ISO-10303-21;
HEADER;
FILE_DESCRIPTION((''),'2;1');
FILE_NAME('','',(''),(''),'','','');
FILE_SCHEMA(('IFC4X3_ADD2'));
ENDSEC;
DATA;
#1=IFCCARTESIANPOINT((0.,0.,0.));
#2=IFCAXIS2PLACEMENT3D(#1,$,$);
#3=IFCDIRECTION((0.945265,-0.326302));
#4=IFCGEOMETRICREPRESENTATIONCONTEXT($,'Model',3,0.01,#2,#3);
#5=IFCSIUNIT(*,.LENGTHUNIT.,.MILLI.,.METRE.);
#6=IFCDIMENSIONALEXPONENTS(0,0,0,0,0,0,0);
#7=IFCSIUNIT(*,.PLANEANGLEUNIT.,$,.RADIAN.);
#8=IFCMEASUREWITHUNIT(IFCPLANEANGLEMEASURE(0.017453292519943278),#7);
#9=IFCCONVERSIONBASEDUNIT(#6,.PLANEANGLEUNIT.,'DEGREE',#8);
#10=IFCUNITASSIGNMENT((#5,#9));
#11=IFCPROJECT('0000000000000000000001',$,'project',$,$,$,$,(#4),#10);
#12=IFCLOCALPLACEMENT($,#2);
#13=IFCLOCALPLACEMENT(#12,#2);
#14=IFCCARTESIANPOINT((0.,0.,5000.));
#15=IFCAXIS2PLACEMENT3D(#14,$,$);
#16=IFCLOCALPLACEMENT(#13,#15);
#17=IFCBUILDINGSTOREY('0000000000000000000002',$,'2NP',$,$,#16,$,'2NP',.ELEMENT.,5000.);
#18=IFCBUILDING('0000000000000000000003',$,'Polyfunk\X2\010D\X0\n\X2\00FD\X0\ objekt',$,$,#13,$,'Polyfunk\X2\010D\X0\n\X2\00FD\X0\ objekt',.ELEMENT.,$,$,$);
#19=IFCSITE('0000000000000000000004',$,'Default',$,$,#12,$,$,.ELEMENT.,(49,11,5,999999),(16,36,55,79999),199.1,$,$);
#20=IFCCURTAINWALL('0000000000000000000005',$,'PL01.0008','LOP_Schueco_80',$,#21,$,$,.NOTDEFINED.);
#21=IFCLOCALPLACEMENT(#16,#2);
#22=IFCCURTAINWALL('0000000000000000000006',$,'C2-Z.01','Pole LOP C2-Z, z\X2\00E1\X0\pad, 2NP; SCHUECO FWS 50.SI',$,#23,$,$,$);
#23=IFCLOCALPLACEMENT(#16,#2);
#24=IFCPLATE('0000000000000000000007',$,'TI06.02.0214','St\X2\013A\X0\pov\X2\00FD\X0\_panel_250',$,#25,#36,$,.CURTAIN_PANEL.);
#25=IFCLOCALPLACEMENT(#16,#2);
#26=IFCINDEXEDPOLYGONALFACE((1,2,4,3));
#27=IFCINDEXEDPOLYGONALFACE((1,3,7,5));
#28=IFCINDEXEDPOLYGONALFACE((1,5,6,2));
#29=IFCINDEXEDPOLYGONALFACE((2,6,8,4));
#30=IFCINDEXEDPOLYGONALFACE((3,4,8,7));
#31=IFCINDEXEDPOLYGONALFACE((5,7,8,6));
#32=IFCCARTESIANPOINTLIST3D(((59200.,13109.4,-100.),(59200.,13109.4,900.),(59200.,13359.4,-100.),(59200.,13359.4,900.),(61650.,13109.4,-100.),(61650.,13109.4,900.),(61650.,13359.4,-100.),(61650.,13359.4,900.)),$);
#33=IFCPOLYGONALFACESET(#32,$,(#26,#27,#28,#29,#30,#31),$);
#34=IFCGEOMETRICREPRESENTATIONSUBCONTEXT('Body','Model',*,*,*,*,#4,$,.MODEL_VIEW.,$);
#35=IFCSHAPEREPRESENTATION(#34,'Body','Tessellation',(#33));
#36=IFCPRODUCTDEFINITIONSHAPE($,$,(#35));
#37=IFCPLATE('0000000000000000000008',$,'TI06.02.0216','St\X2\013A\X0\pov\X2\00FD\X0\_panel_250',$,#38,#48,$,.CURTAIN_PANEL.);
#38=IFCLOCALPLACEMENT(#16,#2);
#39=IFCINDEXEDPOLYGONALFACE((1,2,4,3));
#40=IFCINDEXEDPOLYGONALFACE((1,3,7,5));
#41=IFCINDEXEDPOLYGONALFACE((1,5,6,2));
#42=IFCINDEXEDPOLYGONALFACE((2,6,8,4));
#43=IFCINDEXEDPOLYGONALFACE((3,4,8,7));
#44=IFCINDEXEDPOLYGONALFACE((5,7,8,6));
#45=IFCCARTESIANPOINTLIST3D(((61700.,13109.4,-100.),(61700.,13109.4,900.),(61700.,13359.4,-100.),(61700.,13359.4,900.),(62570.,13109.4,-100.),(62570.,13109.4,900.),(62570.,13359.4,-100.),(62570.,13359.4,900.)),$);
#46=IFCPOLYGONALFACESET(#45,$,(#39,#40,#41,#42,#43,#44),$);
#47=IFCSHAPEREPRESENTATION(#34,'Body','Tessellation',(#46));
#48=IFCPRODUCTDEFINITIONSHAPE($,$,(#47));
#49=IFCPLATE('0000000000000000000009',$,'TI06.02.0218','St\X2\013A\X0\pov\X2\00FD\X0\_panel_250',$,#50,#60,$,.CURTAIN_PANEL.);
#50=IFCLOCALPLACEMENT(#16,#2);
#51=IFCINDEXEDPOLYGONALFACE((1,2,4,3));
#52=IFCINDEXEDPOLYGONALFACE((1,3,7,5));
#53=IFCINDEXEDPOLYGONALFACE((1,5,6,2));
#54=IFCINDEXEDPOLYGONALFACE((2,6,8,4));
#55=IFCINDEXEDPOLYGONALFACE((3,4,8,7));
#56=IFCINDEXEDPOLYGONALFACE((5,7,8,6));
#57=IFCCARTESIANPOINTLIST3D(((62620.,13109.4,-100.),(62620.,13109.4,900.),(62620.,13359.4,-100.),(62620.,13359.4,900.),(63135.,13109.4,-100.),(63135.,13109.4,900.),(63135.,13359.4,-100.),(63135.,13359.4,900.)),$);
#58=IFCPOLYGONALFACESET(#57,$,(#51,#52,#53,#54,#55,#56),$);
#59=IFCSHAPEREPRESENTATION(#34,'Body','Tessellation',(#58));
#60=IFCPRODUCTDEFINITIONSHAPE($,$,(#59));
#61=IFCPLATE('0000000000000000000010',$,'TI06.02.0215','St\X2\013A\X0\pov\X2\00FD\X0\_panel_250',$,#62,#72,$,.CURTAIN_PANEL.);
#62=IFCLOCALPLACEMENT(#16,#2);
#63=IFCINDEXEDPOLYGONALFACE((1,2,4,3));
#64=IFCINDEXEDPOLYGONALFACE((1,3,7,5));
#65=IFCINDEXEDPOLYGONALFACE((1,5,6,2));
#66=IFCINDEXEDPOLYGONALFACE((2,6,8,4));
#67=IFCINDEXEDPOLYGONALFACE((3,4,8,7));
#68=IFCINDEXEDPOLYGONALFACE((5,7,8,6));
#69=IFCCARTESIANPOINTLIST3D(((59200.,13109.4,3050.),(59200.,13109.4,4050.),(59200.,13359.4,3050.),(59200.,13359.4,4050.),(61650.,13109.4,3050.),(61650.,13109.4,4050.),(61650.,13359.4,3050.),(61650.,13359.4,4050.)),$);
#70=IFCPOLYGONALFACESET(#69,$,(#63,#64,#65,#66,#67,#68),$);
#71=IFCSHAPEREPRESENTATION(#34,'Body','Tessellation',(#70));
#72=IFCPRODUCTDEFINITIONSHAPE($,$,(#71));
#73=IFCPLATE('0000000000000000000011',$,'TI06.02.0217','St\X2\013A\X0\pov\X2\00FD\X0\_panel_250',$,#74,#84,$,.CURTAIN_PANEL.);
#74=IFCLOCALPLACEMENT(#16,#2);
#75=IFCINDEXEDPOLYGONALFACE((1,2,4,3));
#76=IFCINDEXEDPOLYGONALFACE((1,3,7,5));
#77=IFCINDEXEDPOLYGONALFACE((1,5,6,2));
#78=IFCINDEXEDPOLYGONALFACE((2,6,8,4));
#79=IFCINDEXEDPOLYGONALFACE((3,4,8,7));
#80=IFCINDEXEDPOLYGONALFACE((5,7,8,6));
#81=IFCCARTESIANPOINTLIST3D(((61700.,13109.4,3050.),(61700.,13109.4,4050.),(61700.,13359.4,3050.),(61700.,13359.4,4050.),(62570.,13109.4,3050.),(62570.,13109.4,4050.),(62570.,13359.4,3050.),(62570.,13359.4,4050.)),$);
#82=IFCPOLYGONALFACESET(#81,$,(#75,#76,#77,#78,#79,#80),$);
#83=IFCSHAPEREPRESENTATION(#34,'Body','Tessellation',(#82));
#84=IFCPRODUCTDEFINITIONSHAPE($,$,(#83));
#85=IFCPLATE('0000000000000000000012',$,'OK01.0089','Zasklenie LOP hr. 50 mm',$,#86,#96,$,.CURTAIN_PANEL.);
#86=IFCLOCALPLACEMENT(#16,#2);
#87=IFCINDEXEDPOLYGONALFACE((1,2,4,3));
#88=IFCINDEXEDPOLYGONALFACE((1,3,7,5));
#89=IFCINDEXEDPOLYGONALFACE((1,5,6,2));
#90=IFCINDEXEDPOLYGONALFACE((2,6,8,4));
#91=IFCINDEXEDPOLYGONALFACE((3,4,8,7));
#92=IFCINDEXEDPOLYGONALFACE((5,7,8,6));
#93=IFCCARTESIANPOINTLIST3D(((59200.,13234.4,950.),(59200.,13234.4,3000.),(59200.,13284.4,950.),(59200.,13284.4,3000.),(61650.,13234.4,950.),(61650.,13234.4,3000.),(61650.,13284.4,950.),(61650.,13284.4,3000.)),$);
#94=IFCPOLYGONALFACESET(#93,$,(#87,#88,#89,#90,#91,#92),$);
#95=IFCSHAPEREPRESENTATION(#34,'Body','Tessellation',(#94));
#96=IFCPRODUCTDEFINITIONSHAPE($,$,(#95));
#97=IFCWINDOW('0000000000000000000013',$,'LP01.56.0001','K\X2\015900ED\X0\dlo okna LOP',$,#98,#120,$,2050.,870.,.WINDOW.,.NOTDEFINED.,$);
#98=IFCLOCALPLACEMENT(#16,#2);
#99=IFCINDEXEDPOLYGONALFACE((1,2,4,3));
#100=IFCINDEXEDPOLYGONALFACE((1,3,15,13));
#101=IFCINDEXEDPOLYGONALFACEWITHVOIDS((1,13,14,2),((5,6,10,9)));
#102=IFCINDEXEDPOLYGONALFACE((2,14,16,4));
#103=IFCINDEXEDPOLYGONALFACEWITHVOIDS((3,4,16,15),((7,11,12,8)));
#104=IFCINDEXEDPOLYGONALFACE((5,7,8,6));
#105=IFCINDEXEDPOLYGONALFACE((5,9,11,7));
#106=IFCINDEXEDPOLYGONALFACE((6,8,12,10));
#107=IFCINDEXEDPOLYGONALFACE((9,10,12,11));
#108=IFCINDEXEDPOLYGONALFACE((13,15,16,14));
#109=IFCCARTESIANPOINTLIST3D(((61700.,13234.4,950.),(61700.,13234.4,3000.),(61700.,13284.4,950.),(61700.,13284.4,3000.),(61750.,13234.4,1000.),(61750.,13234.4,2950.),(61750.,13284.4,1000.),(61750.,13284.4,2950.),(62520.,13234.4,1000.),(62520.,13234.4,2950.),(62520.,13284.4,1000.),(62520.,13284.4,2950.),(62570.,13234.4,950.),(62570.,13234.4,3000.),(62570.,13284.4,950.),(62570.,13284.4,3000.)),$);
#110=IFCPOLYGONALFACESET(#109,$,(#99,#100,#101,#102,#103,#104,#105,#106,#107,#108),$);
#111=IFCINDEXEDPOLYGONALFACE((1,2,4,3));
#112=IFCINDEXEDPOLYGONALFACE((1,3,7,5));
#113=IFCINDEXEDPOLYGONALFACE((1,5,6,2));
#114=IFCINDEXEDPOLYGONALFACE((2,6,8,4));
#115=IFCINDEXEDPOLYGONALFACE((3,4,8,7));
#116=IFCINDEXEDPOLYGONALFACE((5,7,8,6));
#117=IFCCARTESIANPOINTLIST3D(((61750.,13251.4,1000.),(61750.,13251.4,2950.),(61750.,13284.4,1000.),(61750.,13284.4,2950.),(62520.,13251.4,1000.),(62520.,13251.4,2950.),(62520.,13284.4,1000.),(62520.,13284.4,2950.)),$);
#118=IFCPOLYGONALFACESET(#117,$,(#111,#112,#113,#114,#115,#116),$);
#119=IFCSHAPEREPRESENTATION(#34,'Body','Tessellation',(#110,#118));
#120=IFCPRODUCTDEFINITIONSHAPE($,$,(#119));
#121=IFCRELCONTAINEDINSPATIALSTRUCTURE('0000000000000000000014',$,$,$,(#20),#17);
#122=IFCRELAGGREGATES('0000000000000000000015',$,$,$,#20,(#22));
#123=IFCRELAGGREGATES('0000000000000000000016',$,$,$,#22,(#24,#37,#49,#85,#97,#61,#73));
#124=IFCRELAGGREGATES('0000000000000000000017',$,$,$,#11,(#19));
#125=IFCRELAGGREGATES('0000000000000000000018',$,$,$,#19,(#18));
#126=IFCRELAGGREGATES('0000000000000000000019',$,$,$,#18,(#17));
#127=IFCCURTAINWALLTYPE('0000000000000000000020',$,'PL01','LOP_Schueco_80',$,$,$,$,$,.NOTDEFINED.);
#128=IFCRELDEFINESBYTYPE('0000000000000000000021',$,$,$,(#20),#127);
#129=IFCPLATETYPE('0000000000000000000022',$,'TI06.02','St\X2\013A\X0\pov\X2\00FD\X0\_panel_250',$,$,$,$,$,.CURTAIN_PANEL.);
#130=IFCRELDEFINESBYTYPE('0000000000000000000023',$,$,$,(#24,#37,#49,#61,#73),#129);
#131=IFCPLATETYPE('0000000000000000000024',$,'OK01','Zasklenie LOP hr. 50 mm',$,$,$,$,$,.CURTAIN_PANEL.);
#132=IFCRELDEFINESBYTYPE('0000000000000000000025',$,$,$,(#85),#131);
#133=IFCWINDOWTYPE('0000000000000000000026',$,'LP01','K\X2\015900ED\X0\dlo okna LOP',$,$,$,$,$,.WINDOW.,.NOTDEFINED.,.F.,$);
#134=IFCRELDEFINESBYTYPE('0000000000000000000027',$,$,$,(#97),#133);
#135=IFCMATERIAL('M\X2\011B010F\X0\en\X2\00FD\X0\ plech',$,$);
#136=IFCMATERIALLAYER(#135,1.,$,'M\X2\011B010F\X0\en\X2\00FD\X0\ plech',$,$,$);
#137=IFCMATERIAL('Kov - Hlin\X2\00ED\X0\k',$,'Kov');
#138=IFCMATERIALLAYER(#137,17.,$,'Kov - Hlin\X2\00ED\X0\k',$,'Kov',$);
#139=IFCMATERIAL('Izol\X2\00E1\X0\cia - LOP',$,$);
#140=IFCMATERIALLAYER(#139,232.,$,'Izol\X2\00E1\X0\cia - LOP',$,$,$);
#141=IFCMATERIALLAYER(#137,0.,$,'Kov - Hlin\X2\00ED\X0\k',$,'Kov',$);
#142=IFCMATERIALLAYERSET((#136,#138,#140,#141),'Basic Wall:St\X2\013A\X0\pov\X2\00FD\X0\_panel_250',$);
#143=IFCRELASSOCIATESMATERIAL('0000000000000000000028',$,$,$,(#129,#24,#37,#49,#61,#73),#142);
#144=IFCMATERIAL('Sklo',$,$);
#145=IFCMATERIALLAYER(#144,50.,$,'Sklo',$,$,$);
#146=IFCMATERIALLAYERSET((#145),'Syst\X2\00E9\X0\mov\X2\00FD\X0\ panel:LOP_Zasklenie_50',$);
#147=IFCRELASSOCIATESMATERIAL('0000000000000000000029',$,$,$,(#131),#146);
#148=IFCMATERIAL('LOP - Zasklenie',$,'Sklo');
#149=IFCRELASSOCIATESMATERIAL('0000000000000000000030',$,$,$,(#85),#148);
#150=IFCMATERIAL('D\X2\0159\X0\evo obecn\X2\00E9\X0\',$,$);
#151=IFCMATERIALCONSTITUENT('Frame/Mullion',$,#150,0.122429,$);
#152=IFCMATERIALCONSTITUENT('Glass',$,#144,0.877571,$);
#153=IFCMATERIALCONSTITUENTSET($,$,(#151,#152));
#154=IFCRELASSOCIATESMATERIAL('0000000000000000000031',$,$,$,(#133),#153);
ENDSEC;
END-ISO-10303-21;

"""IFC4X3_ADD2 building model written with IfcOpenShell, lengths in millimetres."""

from ifc_helpers import new_model, entity, si_unit, converted_unit, direction, frame, frame_2d, origin, origin_2d_with_axis, place, context, subcontext, project, spatial, polyline, rectangle, outline, extrude, source, transform, mapped, material, layer, layer_set, layer_usage, constituent, constituent_set, type_object, type_shapes, element, aggregate, save


model = new_model("IFC4X3_ADD2")

# Units and contexts
model_context = context("Model", 3, precision=0.01, world=origin(), true_north=direction((0.945265, -0.326302)))
body_context = subcontext(model_context, "Body", "Model", "MODEL_VIEW")
ifc_project = project(units=[si_unit("LENGTHUNIT", "METRE", prefix="MILLI"), converted_unit("PLANEANGLEUNIT", "DEGREE", entity("IfcPlaneAngleMeasure", 0.017453292519943278), si_unit("PLANEANGLEUNIT", "RADIAN"), dimensions=[0, 0, 0, 0, 0, 0, 0])], contexts=[model_context])

# Site, building, storey
site_placement = place(None, origin())
site = spatial("IfcSite", under=ifc_project, at=site_placement, Name="Default", CompositionType="ELEMENT", RefLatitude=(49, 11, 5, 999999), RefLongitude=(16, 36, 55, 79999), RefElevation=199.1)
building_placement = place(site_placement, origin())
building = spatial("IfcBuilding", under=site, at=building_placement, Name="Polyfunkčný objekt", LongName="Polyfunkčný objekt", CompositionType="ELEMENT")
storey_placement = place(building_placement, frame((0.0, 0.0, 5000.0)))
storey = spatial("IfcBuildingStorey", under=building, at=storey_placement, Name="2NP", LongName="2NP", CompositionType="ELEMENT", Elevation=5000.0)

# Curtain walls, plates, window
curtain_wall_type = type_object("IfcCurtainWallType", Name="PL01", Description="LOP_Schueco_80", PredefinedType="NOTDEFINED")
curtain_wall_1_placement = place(storey_placement, frame((0.0, 0.0, -5000.0)))
curtain_wall_1 = element("IfcCurtainWall", 1, at=curtain_wall_1_placement, inside=storey, type_object=curtain_wall_type, Name="PL01.0008", Description="LOP_Schueco_80", PredefinedType="NOTDEFINED")
curtain_wall_2 = element("IfcCurtainWall", 2, Name="C2-Z.01", Description="Pole LOP C2-Z, západ, 2NP; SCHUECO FWS 50.SI")
aggregate(curtain_wall_1, [curtain_wall_2])
ifc_material_1 = material(Name="Měďený plech")
ifc_layer_1 = layer(ifc_material_1, 1.0, Name="Měďený plech")
ifc_material_2 = material(Name="Kov - Hliník", Category="Kov")
ifc_layer_2 = layer(ifc_material_2, 17.0, Name="Kov - Hliník", Category="Kov")
ifc_material_3 = material(Name="Izolácia - LOP")
ifc_layer_3 = layer(ifc_material_3, 232.0, Name="Izolácia - LOP")
ifc_layer_4 = layer(ifc_material_2, 0.0, Name="Kov - Hliník", Category="Kov")
ifc_layer_set_1 = layer_set([ifc_layer_1, ifc_layer_2, ifc_layer_3, ifc_layer_4], Name="Basic Wall:Stĺpový_panel_250")
ifc_layer_usage_1 = layer_usage(ifc_layer_set_1, "AXIS2", "NEGATIVE", 125.0)
plate_type_1 = type_object("IfcPlateType", Name="TI06.02", Description="Stĺpový_panel_250", PredefinedType="CURTAIN_PANEL", material=ifc_layer_set_1)
plate_1_placement = place(storey_placement, frame((59200.0, 13234.4, -100.0)))
plate_1 = element("IfcPlate", 3, at=plate_1_placement, type_object=plate_type_1, material=ifc_layer_usage_1, Name="TI06.02.0214", Description="Stĺpový_panel_250", PredefinedType="CURTAIN_PANEL", context=body_context, shape_type="SweptSolid", body=[
    extrude(rectangle(XDim=250.0, YDim=2450.0, at=frame_2d((0.0, 0.0), x_axis=(1.0, 0.0))), frame((1225.0, 0.0, 0.0), z_axis=(0.0, 0.0, 1.0), x_axis=(0.0, 1.0, 0.0)), (0.0, 0.0, 1.0), 1000.0),
])
ifc_layer_usage_2 = layer_usage(ifc_layer_set_1, "AXIS2", "NEGATIVE", 125.0)
plate_2_placement = place(storey_placement, frame((61700.0, 13234.4, -100.0)))
plate_2 = element("IfcPlate", 4, at=plate_2_placement, type_object=plate_type_1, material=ifc_layer_usage_2, Name="TI06.02.0216", Description="Stĺpový_panel_250", PredefinedType="CURTAIN_PANEL", context=body_context, shape_type="SweptSolid", body=[
    extrude(rectangle(XDim=250.0, YDim=870.0, at=frame_2d((0.0, 0.0), x_axis=(1.0, 0.0))), frame((435.0, 0.0, 0.0), z_axis=(0.0, 0.0, 1.0), x_axis=(0.0, 1.0, 0.0)), (0.0, 0.0, 1.0), 1000.0),
])
ifc_layer_usage_3 = layer_usage(ifc_layer_set_1, "AXIS2", "NEGATIVE", 125.0)
plate_3_placement = place(storey_placement, frame((62620.0, 13234.4, -100.0)))
plate_3 = element("IfcPlate", 5, at=plate_3_placement, type_object=plate_type_1, material=ifc_layer_usage_3, Name="TI06.02.0218", Description="Stĺpový_panel_250", PredefinedType="CURTAIN_PANEL", context=body_context, shape_type="SweptSolid", body=[
    extrude(rectangle(XDim=250.0, YDim=515.0, at=frame_2d((0.0, 0.0), x_axis=(1.0, 0.0))), frame((257.5, 0.0, 0.0), z_axis=(0.0, 0.0, 1.0), x_axis=(0.0, 1.0, 0.0)), (0.0, 0.0, 1.0), 1000.0),
])
ifc_layer_usage_4 = layer_usage(ifc_layer_set_1, "AXIS2", "NEGATIVE", 125.0)
plate_4_placement = place(storey_placement, frame((59200.0, 13234.4, 3050.0)))
plate_4 = element("IfcPlate", 6, at=plate_4_placement, type_object=plate_type_1, material=ifc_layer_usage_4, Name="TI06.02.0215", Description="Stĺpový_panel_250", PredefinedType="CURTAIN_PANEL", context=body_context, shape_type="SweptSolid", body=[
    extrude(rectangle(XDim=250.0, YDim=2450.0, at=frame_2d((0.0, 0.0), x_axis=(1.0, 0.0))), frame((1225.0, 0.0, 0.0), z_axis=(0.0, 0.0, 1.0), x_axis=(0.0, 1.0, 0.0)), (0.0, 0.0, 1.0), 1000.0),
])
ifc_layer_usage_5 = layer_usage(ifc_layer_set_1, "AXIS2", "NEGATIVE", 125.0)
plate_5_placement = place(storey_placement, frame((61700.0, 13234.4, 3050.0)))
plate_5 = element("IfcPlate", 7, at=plate_5_placement, type_object=plate_type_1, material=ifc_layer_usage_5, Name="TI06.02.0217", Description="Stĺpový_panel_250", PredefinedType="CURTAIN_PANEL", context=body_context, shape_type="SweptSolid", body=[
    extrude(rectangle(XDim=250.0, YDim=870.0, at=frame_2d((0.0, 0.0), x_axis=(1.0, 0.0))), frame((435.0, 0.0, 0.0), z_axis=(0.0, 0.0, 1.0), x_axis=(0.0, 1.0, 0.0)), (0.0, 0.0, 1.0), 1000.0),
])
ifc_material_4 = material(Name="LOP - Zasklenie", Category="Sklo")
ifc_material_5 = material(Name="Sklo")
ifc_layer_5 = layer(ifc_material_5, 50.0, Name="Sklo")
ifc_layer_set_2 = layer_set([ifc_layer_5], Name="Systémový panel:LOP_Zasklenie_50")
plate_type_2 = type_object("IfcPlateType", Name="OK01", Description="Zasklenie LOP hr. 50 mm", PredefinedType="CURTAIN_PANEL", material=ifc_layer_set_2)
shared_shape_1 = source(origin(), body_context, "Body", "SweptSolid", [
    extrude(rectangle(XDim=50.0, YDim=2450.0, at=origin_2d_with_axis()), frame((0.0, 25.0, 0.0), z_axis=(0.0, 0.0, 1.0), x_axis=(0.0, 1.0, 0.0)), (0.0, 0.0, 1.0), 2050.0),
])
type_shapes(plate_type_2, [shared_shape_1])
plate_6_placement = place(curtain_wall_1_placement, frame((60425.0, 13234.4, 5950.0)))
plate_6 = element("IfcPlate", 8, at=plate_6_placement, type_object=plate_type_2, material=ifc_material_4, Name="OK01.0089", Description="Zasklenie LOP hr. 50 mm", PredefinedType="CURTAIN_PANEL", context=body_context, shape_type="MappedRepresentation", body=[
    mapped(shared_shape_1, transform((0.0, 0.0, 0.0), scale=1.0)),
])
ifc_material_6 = material(Name="Dřevo obecné")
ifc_constituent_1 = constituent(ifc_material_6, Name="Frame/Mullion", fraction=0.122429)
ifc_constituent_2 = constituent(ifc_material_5, Name="Glass", fraction=0.877571)
ifc_constituent_set = constituent_set(constituents=[ifc_constituent_1, ifc_constituent_2])
window_type = type_object("IfcWindowType", Name="LP01", Description="Křídlo okna LOP", ParameterTakesPrecedence=False, PartitioningType="NOTDEFINED", PredefinedType="WINDOW", material=ifc_constituent_set)
shared_shape_2 = source(origin(), body_context, "Body", "SweptSolid", [
    extrude(outline(polyline([(-1025.0, -435.0), (1025.0, -435.0), (1025.0, 435.0), (-1025.0, 435.0), (-1025.0, -435.0)]), holes=[polyline([(-975.0, -385.0), (-975.0, 385.0), (975.0, 385.0), (975.0, -385.0), (-975.0, -385.0)])]), frame((0.0, 0.0, 1025.0), z_axis=(0.0, 1.0, 0.0), x_axis=(0.0, 0.0, -1.0)), (0.0, 0.0, 1.0), 50.0),
    extrude(rectangle(XDim=33.0, YDim=770.0, at=origin_2d_with_axis()), frame((0.0, 33.5, 50.0), z_axis=(0.0, 0.0, 1.0), x_axis=(0.0, -1.0, 0.0)), (0.0, 0.0, 1.0), 1950.0),
])
type_shapes(window_type, [shared_shape_2])
window_placement = place(curtain_wall_1_placement, frame((62135.0, 13234.4, 5950.0)))
window = element("IfcWindow", 9, at=window_placement, type_object=window_type, Name="LP01.56.0001", Description="Křídlo okna LOP", OverallHeight=2050.0, OverallWidth=870.0, PartitioningType="NOTDEFINED", PredefinedType="WINDOW", context=body_context, shape_type="MappedRepresentation", body=[
    mapped(shared_shape_2, transform((0.0, 0.0, 0.0), scale=1.0)),
])
aggregate(curtain_wall_2, [plate_1, plate_2, plate_3, plate_6, window, plate_4, plate_5])

save(model, "model.ifc")
